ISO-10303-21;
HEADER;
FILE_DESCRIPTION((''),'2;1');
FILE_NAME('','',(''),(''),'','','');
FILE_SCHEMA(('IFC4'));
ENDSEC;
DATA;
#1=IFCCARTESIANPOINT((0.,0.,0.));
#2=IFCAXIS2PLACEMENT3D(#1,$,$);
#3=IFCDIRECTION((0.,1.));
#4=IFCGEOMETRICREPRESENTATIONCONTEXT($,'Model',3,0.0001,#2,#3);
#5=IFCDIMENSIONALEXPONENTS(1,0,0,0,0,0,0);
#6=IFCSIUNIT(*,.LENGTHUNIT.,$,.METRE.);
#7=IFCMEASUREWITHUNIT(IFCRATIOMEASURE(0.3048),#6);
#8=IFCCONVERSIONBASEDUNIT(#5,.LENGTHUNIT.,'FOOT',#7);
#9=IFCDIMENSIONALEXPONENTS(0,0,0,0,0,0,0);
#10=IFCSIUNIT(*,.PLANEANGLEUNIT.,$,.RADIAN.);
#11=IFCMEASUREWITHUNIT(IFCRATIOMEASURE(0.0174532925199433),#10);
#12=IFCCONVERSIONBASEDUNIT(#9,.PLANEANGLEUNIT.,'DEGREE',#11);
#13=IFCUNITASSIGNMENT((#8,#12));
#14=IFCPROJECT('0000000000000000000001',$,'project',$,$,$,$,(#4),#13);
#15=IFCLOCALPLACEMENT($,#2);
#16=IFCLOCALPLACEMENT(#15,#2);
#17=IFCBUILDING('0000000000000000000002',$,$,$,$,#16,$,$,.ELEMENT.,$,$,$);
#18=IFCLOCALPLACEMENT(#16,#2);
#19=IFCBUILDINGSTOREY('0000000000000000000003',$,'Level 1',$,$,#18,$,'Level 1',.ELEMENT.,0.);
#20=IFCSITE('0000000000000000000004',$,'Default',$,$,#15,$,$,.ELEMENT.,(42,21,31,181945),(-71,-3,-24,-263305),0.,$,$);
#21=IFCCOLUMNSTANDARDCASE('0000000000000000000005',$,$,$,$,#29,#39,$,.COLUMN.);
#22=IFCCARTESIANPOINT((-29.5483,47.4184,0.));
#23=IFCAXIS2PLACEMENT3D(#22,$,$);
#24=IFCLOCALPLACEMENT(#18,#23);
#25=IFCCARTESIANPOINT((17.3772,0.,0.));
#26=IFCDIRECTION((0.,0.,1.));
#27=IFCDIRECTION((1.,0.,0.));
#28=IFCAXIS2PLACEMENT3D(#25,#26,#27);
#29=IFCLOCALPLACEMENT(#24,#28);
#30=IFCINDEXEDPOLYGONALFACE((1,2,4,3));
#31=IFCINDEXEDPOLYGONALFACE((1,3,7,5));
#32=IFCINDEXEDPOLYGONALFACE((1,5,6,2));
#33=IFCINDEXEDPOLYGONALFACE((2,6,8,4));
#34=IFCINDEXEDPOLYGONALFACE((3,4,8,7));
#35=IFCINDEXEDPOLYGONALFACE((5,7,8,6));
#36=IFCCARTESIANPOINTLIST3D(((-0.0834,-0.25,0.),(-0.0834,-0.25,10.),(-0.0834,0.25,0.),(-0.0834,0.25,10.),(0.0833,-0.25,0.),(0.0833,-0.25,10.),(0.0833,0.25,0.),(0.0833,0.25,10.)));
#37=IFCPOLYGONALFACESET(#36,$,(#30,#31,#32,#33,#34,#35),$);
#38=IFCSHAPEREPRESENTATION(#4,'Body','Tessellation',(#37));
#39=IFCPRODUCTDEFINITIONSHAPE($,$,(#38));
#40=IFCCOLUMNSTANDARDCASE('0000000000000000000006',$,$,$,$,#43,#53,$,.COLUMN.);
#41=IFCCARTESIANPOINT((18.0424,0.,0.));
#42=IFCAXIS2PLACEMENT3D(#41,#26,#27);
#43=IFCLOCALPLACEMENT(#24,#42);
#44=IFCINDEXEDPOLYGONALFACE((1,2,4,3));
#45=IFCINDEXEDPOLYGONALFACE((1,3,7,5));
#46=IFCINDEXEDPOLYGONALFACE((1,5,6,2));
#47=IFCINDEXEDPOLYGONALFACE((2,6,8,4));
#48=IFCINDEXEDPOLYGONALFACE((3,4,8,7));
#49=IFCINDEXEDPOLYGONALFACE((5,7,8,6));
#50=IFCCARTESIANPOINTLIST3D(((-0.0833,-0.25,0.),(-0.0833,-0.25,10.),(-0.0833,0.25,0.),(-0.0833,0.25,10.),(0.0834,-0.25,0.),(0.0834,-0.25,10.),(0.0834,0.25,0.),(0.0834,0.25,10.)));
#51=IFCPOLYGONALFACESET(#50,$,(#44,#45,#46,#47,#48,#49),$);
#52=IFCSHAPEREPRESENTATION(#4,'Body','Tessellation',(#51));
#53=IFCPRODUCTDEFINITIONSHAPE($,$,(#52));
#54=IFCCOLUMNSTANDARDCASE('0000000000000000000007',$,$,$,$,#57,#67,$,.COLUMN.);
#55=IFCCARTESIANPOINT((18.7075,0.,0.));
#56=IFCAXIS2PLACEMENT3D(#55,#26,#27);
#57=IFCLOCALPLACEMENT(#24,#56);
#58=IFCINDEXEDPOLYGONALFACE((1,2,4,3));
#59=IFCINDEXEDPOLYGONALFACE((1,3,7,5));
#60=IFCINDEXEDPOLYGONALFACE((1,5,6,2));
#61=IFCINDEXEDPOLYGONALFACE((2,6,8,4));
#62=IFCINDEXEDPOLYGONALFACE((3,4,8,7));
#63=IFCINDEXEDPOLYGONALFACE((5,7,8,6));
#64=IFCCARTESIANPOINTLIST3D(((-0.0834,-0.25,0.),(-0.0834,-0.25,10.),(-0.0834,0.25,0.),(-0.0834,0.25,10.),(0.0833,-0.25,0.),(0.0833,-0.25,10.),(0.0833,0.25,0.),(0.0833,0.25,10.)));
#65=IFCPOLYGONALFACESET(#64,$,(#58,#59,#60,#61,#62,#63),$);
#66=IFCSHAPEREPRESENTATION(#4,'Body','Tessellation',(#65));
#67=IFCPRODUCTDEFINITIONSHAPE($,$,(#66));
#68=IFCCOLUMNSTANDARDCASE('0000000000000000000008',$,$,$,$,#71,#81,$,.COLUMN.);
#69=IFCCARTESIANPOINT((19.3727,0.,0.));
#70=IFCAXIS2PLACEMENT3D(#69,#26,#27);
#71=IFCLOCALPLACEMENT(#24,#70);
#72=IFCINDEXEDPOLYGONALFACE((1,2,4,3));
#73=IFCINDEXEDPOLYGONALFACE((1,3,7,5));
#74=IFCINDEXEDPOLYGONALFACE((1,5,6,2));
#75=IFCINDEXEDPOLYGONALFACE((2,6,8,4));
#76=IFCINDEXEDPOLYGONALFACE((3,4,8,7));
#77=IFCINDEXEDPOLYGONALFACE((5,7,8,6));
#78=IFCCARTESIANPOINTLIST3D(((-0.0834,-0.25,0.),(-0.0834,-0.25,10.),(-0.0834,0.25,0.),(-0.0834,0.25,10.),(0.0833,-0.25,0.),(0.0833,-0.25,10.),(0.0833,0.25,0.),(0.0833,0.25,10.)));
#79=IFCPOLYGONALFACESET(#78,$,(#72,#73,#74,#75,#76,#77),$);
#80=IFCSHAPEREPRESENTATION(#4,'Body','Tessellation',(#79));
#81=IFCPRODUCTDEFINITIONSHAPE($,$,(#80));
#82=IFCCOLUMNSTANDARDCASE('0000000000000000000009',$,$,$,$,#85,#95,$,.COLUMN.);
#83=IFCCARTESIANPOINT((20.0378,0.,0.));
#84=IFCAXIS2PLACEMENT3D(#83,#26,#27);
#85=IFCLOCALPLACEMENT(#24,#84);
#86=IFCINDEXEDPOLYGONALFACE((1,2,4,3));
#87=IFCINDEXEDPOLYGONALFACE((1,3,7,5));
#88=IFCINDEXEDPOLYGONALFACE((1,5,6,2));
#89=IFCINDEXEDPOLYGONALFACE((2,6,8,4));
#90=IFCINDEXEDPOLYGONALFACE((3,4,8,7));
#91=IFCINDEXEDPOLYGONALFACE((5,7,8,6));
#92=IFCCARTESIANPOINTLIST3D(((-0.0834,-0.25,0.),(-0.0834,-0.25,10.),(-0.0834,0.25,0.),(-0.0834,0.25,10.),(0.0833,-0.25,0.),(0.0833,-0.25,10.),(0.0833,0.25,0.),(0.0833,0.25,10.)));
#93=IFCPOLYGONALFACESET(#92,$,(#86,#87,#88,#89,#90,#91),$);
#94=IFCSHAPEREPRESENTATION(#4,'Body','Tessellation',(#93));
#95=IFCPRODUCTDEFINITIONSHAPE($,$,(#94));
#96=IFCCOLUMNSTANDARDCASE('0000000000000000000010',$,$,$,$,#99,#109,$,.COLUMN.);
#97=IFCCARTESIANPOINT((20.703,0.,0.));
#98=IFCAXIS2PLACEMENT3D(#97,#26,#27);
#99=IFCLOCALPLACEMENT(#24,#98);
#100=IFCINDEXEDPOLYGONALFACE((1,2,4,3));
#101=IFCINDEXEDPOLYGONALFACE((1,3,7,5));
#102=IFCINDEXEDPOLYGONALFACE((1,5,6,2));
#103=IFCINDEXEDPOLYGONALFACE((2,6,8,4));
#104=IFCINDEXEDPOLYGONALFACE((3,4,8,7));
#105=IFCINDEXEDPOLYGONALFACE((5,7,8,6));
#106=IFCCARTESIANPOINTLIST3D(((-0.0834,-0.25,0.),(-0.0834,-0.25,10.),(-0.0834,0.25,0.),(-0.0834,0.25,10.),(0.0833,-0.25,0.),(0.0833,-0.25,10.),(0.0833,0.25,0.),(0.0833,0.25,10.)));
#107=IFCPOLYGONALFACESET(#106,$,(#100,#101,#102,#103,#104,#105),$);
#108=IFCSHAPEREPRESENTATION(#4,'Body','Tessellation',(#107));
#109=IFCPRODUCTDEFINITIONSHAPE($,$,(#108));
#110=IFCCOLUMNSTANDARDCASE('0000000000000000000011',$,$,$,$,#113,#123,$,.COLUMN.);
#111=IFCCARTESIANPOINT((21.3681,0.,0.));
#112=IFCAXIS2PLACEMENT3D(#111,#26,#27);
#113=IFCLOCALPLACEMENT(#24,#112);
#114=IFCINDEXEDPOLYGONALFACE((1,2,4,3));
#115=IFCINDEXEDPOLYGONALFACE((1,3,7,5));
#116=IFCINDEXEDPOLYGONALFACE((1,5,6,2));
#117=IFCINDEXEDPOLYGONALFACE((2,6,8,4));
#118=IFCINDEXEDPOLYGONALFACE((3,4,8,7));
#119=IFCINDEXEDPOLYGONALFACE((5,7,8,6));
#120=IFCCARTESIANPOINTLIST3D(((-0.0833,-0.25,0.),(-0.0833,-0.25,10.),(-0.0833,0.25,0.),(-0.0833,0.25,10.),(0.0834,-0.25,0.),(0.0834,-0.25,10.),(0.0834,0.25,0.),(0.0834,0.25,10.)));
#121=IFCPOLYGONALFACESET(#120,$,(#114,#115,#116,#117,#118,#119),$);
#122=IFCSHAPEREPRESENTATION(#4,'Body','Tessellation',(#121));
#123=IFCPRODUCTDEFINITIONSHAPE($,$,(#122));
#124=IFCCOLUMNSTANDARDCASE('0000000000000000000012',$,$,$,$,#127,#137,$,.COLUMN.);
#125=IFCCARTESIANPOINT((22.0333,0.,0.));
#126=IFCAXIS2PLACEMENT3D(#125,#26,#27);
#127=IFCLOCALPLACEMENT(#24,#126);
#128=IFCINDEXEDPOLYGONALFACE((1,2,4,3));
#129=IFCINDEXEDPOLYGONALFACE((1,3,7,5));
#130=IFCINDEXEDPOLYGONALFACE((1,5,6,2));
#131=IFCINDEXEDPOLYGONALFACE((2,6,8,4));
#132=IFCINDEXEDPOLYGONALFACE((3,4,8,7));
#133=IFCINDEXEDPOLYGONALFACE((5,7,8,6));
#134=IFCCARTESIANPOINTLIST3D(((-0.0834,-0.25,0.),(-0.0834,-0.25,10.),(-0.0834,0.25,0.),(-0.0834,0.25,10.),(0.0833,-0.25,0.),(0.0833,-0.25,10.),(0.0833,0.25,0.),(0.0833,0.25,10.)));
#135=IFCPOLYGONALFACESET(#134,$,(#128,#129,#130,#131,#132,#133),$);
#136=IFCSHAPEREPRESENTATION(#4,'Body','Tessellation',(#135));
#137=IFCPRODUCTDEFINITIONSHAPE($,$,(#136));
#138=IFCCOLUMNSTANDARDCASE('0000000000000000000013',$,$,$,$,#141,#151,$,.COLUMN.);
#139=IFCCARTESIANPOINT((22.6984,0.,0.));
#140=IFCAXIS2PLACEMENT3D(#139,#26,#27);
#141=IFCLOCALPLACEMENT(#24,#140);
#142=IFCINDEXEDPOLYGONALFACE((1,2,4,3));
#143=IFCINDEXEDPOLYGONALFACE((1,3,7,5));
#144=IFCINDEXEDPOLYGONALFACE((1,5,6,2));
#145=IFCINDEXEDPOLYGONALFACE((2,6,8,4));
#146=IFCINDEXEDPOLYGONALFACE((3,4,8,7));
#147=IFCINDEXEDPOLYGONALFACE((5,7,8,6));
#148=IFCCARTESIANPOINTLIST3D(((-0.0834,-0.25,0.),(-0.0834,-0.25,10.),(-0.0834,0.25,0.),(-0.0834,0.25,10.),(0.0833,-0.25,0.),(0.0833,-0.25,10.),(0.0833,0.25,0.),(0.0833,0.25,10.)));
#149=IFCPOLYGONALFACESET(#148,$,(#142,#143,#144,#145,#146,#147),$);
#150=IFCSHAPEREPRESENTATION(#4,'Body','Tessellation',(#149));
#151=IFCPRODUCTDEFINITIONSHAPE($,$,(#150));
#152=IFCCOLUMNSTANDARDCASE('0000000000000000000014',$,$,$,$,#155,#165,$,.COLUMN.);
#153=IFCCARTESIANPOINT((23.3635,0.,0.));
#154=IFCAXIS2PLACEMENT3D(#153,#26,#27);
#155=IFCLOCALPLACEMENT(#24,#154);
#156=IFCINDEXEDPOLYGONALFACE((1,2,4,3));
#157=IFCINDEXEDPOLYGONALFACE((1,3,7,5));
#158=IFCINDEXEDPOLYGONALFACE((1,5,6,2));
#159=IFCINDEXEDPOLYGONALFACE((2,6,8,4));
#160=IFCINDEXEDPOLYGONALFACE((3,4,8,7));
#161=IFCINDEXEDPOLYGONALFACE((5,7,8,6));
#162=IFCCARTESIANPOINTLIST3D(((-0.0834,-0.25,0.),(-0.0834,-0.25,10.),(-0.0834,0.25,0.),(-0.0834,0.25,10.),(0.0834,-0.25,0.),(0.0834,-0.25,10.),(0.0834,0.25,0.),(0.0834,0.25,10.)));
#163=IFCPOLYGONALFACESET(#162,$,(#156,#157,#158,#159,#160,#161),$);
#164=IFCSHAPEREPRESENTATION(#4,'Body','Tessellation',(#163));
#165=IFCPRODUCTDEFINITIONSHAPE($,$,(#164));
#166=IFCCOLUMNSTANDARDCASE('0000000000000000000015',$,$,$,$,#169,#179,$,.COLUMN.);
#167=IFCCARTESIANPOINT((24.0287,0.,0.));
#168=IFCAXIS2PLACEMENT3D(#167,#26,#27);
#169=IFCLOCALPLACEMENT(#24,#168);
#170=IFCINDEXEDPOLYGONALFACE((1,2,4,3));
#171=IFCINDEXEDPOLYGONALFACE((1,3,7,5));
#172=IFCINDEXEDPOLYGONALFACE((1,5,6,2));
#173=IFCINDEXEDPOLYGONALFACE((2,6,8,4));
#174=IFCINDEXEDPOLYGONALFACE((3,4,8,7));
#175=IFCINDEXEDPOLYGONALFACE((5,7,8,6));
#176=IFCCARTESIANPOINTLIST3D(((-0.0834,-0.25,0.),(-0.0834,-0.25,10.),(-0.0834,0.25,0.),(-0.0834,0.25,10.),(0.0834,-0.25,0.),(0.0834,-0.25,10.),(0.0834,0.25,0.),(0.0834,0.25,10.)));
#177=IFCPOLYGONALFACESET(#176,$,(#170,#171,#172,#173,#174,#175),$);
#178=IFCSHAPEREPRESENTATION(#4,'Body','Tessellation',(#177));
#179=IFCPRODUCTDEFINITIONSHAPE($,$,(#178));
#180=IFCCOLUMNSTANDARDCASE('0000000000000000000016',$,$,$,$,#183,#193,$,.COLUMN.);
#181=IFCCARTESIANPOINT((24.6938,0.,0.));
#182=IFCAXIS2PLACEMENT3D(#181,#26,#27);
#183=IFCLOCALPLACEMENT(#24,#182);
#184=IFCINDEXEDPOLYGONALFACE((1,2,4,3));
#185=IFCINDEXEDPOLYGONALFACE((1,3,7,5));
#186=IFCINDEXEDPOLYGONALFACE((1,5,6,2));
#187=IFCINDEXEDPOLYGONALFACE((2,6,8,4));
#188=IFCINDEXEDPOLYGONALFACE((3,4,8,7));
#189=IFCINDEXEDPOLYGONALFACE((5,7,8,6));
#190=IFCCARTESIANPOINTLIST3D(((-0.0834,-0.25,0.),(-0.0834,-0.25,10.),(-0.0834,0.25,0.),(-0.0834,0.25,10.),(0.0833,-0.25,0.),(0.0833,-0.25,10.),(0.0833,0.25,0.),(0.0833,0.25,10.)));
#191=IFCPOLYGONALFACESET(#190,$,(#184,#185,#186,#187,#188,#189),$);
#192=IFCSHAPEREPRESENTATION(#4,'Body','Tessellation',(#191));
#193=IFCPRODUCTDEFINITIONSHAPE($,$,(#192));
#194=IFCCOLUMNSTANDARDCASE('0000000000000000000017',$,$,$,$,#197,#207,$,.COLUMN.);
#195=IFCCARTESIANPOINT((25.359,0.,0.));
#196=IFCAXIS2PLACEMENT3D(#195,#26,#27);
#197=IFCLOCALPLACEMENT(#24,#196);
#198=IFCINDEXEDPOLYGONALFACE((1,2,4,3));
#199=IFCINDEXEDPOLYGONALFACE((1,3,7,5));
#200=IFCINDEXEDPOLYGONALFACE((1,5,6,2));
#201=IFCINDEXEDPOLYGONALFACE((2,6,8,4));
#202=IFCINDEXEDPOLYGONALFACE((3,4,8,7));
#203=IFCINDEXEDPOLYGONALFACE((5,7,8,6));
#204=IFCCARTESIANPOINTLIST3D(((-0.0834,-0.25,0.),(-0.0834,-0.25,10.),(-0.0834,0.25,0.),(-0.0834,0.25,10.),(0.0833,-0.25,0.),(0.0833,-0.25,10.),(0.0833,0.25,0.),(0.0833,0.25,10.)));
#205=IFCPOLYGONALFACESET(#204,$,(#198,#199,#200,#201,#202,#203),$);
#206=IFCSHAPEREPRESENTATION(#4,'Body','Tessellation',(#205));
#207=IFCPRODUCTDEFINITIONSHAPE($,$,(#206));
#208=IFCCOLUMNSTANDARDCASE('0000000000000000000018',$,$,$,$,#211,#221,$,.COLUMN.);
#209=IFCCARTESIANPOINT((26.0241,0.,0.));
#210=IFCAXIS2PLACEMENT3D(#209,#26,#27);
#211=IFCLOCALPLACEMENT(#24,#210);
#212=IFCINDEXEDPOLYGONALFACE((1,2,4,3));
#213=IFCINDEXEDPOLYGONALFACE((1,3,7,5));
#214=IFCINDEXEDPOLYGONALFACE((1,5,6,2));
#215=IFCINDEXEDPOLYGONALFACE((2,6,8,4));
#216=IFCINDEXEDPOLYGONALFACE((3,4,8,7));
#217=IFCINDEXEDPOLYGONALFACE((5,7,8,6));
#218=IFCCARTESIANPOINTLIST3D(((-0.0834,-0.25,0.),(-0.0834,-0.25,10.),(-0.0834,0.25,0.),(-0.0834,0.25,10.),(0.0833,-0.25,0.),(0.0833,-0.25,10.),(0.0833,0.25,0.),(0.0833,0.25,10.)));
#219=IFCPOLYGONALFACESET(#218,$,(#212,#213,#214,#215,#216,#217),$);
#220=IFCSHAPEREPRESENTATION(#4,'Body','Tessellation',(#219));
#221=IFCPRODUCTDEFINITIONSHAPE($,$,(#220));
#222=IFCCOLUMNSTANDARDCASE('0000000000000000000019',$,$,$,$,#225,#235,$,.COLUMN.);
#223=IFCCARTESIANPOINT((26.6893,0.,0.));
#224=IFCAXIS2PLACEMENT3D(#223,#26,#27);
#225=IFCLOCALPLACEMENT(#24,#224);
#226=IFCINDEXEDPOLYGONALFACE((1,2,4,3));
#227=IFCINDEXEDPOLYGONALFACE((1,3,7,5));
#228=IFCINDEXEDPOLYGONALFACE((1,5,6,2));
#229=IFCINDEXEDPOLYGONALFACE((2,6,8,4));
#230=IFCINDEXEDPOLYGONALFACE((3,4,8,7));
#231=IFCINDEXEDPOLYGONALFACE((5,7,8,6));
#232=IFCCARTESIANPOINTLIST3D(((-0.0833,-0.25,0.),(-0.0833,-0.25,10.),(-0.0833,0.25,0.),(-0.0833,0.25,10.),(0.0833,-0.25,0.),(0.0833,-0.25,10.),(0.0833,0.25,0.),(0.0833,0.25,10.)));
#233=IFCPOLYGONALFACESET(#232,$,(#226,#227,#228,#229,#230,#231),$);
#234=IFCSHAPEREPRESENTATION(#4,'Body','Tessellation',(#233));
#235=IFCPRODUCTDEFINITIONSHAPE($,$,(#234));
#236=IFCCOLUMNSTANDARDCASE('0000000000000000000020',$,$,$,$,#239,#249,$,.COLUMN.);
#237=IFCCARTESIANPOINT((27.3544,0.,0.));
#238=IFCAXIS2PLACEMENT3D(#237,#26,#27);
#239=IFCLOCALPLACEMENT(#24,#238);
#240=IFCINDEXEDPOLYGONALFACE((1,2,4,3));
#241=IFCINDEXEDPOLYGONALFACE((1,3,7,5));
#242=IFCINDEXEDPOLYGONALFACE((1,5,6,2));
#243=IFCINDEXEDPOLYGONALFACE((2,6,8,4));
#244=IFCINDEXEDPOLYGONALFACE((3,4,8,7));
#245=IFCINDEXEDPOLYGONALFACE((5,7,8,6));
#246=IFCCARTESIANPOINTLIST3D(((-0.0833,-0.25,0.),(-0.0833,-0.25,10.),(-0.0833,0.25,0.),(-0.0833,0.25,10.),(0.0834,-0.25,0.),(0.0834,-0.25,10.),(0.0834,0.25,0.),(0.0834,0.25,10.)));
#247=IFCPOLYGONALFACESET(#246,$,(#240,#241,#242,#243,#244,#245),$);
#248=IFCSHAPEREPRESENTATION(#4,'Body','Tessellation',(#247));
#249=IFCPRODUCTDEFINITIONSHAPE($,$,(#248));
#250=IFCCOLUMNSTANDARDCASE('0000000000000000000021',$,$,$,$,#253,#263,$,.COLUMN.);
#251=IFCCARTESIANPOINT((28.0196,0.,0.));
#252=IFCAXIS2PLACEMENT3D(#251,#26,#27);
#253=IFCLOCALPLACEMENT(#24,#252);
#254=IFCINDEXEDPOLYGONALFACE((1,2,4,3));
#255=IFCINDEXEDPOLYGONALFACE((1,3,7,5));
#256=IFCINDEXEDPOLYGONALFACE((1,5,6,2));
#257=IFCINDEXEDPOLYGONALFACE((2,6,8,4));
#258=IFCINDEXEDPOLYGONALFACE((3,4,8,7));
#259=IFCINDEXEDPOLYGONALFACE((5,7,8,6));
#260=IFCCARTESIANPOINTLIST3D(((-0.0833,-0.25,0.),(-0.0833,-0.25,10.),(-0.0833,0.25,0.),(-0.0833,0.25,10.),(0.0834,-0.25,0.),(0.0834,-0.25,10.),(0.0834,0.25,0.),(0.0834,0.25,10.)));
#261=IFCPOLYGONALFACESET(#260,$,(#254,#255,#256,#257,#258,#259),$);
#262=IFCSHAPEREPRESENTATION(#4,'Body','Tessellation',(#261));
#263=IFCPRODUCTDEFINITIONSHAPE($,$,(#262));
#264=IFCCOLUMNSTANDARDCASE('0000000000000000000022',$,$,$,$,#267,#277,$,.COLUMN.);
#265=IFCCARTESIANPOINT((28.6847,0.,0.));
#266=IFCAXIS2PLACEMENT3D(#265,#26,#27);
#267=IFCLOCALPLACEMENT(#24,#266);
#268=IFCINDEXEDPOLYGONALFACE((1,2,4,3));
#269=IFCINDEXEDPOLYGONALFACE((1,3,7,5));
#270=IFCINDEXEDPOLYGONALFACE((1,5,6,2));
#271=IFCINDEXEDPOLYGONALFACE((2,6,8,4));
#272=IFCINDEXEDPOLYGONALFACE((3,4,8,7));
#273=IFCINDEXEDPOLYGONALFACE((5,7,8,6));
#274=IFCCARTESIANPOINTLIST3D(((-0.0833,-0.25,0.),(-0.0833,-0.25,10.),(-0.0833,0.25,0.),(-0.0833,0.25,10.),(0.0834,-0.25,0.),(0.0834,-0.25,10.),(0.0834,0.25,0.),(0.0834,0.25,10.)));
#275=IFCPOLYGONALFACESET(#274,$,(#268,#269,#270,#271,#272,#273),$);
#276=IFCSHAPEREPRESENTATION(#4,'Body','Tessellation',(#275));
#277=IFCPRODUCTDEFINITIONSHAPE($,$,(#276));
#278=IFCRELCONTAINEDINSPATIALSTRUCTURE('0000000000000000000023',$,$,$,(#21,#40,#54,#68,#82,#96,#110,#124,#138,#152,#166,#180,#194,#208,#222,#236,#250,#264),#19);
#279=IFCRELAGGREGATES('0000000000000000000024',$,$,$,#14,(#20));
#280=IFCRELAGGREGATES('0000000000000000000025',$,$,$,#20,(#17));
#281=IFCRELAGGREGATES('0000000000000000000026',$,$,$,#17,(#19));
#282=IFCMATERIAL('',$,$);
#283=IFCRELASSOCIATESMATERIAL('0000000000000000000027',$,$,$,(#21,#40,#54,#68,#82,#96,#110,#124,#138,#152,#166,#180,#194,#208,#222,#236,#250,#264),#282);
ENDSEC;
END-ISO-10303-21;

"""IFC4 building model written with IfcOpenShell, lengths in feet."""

from ifc_helpers import new_model, entity, si_unit, converted_unit, direction, frame, origin, place, context, project, spatial, rectangle, extrude, material, element, save


model = new_model("IFC4")

# Units and contexts
model_context = context("Model", 3, precision=0.0001, world=origin(), true_north=direction((0.0, 1.0)))
ifc_project = project(units=[converted_unit("LENGTHUNIT", "FOOT", entity("IfcRatioMeasure", 0.3048), si_unit("LENGTHUNIT", "METRE"), dimensions=[1, 0, 0, 0, 0, 0, 0]), converted_unit("PLANEANGLEUNIT", "DEGREE", entity("IfcRatioMeasure", 0.0174532925199433), si_unit("PLANEANGLEUNIT", "RADIAN"), dimensions=[0, 0, 0, 0, 0, 0, 0])], contexts=[model_context])

# Site, building, storey
site_placement = place(None, origin())
site = spatial("IfcSite", under=ifc_project, at=site_placement, Name="Default", CompositionType="ELEMENT", RefLatitude=(42, 21, 31, 181945), RefLongitude=(-71, -3, -24, -263305), RefElevation=0.0)
building_placement = place(site_placement, origin())
building = spatial("IfcBuilding", under=site, at=building_placement, CompositionType="ELEMENT")
storey_placement = place(building_placement, origin())
storey = spatial("IfcBuildingStorey", under=building, at=storey_placement, Name="Level 1", LongName="Level 1", CompositionType="ELEMENT", Elevation=0.0)

# Columns
ifc_material = material(Name="")
placement = place(storey_placement, frame((-29.5483, 47.4184, 0.0)))
for number, where, z_axis, x_axis in (
    (1, (17.3772, 0.0, 0.0), (0.0, 0.0, 1.0), (1.0, 0.0, 0.0)),
    (2, (18.0424, 0.0, 0.0), (0.0, 0.0, 1.0), (1.0, 0.0, 0.0)),
    (3, (18.7075, 0.0, 0.0), (0.0, 0.0, 1.0), (1.0, 0.0, 0.0)),
    (4, (19.3727, 0.0, 0.0), (0.0, 0.0, 1.0), (1.0, 0.0, 0.0)),
    (5, (20.0378, 0.0, 0.0), (0.0, 0.0, 1.0), (1.0, 0.0, 0.0)),
    (6, (20.703, 0.0, 0.0), (0.0, 0.0, 1.0), (1.0, 0.0, 0.0)),
    (7, (21.3681, 0.0, 0.0), (0.0, 0.0, 1.0), (1.0, 0.0, 0.0)),
    (8, (22.0333, 0.0, 0.0), (0.0, 0.0, 1.0), (1.0, 0.0, 0.0)),
    (9, (22.6984, 0.0, 0.0), (0.0, 0.0, 1.0), (1.0, 0.0, 0.0)),
    (10, (23.3635, 0.0, 0.0), (0.0, 0.0, 1.0), (1.0, 0.0, 0.0)),
    (11, (24.0287, 0.0, 0.0), (0.0, 0.0, 1.0), (1.0, 0.0, 0.0)),
    (12, (24.6938, 0.0, 0.0), (0.0, 0.0, 1.0), (1.0, 0.0, 0.0)),
    (13, (25.359, 0.0, 0.0), (0.0, 0.0, 1.0), (1.0, 0.0, 0.0)),
    (14, (26.0241, 0.0, 0.0), (0.0, 0.0, 1.0), (1.0, 0.0, 0.0)),
    (15, (26.6893, 0.0, 0.0), (0.0, 0.0, 1.0), (1.0, 0.0, 0.0)),
    (16, (27.3544, 0.0, 0.0), (0.0, 0.0, 1.0), (1.0, 0.0, 0.0)),
    (17, (28.0196, 0.0, 0.0), (0.0, 0.0, 1.0), (1.0, 0.0, 0.0)),
    (18, (28.6847, 0.0, 0.0), (0.0, 0.0, 1.0), (1.0, 0.0, 0.0)),
):
    element("IfcColumnStandardCase", number, at=place(placement, frame(where, z_axis=z_axis, x_axis=x_axis)), inside=storey, material=ifc_material, PredefinedType="COLUMN", context=model_context, shape_type="SweptSolid", body=[
        extrude(rectangle(XDim=0.1667, YDim=0.5), origin(), (0.0, 0.0, 1.0), 10.0),
    ])

save(model, "model.ifc")
